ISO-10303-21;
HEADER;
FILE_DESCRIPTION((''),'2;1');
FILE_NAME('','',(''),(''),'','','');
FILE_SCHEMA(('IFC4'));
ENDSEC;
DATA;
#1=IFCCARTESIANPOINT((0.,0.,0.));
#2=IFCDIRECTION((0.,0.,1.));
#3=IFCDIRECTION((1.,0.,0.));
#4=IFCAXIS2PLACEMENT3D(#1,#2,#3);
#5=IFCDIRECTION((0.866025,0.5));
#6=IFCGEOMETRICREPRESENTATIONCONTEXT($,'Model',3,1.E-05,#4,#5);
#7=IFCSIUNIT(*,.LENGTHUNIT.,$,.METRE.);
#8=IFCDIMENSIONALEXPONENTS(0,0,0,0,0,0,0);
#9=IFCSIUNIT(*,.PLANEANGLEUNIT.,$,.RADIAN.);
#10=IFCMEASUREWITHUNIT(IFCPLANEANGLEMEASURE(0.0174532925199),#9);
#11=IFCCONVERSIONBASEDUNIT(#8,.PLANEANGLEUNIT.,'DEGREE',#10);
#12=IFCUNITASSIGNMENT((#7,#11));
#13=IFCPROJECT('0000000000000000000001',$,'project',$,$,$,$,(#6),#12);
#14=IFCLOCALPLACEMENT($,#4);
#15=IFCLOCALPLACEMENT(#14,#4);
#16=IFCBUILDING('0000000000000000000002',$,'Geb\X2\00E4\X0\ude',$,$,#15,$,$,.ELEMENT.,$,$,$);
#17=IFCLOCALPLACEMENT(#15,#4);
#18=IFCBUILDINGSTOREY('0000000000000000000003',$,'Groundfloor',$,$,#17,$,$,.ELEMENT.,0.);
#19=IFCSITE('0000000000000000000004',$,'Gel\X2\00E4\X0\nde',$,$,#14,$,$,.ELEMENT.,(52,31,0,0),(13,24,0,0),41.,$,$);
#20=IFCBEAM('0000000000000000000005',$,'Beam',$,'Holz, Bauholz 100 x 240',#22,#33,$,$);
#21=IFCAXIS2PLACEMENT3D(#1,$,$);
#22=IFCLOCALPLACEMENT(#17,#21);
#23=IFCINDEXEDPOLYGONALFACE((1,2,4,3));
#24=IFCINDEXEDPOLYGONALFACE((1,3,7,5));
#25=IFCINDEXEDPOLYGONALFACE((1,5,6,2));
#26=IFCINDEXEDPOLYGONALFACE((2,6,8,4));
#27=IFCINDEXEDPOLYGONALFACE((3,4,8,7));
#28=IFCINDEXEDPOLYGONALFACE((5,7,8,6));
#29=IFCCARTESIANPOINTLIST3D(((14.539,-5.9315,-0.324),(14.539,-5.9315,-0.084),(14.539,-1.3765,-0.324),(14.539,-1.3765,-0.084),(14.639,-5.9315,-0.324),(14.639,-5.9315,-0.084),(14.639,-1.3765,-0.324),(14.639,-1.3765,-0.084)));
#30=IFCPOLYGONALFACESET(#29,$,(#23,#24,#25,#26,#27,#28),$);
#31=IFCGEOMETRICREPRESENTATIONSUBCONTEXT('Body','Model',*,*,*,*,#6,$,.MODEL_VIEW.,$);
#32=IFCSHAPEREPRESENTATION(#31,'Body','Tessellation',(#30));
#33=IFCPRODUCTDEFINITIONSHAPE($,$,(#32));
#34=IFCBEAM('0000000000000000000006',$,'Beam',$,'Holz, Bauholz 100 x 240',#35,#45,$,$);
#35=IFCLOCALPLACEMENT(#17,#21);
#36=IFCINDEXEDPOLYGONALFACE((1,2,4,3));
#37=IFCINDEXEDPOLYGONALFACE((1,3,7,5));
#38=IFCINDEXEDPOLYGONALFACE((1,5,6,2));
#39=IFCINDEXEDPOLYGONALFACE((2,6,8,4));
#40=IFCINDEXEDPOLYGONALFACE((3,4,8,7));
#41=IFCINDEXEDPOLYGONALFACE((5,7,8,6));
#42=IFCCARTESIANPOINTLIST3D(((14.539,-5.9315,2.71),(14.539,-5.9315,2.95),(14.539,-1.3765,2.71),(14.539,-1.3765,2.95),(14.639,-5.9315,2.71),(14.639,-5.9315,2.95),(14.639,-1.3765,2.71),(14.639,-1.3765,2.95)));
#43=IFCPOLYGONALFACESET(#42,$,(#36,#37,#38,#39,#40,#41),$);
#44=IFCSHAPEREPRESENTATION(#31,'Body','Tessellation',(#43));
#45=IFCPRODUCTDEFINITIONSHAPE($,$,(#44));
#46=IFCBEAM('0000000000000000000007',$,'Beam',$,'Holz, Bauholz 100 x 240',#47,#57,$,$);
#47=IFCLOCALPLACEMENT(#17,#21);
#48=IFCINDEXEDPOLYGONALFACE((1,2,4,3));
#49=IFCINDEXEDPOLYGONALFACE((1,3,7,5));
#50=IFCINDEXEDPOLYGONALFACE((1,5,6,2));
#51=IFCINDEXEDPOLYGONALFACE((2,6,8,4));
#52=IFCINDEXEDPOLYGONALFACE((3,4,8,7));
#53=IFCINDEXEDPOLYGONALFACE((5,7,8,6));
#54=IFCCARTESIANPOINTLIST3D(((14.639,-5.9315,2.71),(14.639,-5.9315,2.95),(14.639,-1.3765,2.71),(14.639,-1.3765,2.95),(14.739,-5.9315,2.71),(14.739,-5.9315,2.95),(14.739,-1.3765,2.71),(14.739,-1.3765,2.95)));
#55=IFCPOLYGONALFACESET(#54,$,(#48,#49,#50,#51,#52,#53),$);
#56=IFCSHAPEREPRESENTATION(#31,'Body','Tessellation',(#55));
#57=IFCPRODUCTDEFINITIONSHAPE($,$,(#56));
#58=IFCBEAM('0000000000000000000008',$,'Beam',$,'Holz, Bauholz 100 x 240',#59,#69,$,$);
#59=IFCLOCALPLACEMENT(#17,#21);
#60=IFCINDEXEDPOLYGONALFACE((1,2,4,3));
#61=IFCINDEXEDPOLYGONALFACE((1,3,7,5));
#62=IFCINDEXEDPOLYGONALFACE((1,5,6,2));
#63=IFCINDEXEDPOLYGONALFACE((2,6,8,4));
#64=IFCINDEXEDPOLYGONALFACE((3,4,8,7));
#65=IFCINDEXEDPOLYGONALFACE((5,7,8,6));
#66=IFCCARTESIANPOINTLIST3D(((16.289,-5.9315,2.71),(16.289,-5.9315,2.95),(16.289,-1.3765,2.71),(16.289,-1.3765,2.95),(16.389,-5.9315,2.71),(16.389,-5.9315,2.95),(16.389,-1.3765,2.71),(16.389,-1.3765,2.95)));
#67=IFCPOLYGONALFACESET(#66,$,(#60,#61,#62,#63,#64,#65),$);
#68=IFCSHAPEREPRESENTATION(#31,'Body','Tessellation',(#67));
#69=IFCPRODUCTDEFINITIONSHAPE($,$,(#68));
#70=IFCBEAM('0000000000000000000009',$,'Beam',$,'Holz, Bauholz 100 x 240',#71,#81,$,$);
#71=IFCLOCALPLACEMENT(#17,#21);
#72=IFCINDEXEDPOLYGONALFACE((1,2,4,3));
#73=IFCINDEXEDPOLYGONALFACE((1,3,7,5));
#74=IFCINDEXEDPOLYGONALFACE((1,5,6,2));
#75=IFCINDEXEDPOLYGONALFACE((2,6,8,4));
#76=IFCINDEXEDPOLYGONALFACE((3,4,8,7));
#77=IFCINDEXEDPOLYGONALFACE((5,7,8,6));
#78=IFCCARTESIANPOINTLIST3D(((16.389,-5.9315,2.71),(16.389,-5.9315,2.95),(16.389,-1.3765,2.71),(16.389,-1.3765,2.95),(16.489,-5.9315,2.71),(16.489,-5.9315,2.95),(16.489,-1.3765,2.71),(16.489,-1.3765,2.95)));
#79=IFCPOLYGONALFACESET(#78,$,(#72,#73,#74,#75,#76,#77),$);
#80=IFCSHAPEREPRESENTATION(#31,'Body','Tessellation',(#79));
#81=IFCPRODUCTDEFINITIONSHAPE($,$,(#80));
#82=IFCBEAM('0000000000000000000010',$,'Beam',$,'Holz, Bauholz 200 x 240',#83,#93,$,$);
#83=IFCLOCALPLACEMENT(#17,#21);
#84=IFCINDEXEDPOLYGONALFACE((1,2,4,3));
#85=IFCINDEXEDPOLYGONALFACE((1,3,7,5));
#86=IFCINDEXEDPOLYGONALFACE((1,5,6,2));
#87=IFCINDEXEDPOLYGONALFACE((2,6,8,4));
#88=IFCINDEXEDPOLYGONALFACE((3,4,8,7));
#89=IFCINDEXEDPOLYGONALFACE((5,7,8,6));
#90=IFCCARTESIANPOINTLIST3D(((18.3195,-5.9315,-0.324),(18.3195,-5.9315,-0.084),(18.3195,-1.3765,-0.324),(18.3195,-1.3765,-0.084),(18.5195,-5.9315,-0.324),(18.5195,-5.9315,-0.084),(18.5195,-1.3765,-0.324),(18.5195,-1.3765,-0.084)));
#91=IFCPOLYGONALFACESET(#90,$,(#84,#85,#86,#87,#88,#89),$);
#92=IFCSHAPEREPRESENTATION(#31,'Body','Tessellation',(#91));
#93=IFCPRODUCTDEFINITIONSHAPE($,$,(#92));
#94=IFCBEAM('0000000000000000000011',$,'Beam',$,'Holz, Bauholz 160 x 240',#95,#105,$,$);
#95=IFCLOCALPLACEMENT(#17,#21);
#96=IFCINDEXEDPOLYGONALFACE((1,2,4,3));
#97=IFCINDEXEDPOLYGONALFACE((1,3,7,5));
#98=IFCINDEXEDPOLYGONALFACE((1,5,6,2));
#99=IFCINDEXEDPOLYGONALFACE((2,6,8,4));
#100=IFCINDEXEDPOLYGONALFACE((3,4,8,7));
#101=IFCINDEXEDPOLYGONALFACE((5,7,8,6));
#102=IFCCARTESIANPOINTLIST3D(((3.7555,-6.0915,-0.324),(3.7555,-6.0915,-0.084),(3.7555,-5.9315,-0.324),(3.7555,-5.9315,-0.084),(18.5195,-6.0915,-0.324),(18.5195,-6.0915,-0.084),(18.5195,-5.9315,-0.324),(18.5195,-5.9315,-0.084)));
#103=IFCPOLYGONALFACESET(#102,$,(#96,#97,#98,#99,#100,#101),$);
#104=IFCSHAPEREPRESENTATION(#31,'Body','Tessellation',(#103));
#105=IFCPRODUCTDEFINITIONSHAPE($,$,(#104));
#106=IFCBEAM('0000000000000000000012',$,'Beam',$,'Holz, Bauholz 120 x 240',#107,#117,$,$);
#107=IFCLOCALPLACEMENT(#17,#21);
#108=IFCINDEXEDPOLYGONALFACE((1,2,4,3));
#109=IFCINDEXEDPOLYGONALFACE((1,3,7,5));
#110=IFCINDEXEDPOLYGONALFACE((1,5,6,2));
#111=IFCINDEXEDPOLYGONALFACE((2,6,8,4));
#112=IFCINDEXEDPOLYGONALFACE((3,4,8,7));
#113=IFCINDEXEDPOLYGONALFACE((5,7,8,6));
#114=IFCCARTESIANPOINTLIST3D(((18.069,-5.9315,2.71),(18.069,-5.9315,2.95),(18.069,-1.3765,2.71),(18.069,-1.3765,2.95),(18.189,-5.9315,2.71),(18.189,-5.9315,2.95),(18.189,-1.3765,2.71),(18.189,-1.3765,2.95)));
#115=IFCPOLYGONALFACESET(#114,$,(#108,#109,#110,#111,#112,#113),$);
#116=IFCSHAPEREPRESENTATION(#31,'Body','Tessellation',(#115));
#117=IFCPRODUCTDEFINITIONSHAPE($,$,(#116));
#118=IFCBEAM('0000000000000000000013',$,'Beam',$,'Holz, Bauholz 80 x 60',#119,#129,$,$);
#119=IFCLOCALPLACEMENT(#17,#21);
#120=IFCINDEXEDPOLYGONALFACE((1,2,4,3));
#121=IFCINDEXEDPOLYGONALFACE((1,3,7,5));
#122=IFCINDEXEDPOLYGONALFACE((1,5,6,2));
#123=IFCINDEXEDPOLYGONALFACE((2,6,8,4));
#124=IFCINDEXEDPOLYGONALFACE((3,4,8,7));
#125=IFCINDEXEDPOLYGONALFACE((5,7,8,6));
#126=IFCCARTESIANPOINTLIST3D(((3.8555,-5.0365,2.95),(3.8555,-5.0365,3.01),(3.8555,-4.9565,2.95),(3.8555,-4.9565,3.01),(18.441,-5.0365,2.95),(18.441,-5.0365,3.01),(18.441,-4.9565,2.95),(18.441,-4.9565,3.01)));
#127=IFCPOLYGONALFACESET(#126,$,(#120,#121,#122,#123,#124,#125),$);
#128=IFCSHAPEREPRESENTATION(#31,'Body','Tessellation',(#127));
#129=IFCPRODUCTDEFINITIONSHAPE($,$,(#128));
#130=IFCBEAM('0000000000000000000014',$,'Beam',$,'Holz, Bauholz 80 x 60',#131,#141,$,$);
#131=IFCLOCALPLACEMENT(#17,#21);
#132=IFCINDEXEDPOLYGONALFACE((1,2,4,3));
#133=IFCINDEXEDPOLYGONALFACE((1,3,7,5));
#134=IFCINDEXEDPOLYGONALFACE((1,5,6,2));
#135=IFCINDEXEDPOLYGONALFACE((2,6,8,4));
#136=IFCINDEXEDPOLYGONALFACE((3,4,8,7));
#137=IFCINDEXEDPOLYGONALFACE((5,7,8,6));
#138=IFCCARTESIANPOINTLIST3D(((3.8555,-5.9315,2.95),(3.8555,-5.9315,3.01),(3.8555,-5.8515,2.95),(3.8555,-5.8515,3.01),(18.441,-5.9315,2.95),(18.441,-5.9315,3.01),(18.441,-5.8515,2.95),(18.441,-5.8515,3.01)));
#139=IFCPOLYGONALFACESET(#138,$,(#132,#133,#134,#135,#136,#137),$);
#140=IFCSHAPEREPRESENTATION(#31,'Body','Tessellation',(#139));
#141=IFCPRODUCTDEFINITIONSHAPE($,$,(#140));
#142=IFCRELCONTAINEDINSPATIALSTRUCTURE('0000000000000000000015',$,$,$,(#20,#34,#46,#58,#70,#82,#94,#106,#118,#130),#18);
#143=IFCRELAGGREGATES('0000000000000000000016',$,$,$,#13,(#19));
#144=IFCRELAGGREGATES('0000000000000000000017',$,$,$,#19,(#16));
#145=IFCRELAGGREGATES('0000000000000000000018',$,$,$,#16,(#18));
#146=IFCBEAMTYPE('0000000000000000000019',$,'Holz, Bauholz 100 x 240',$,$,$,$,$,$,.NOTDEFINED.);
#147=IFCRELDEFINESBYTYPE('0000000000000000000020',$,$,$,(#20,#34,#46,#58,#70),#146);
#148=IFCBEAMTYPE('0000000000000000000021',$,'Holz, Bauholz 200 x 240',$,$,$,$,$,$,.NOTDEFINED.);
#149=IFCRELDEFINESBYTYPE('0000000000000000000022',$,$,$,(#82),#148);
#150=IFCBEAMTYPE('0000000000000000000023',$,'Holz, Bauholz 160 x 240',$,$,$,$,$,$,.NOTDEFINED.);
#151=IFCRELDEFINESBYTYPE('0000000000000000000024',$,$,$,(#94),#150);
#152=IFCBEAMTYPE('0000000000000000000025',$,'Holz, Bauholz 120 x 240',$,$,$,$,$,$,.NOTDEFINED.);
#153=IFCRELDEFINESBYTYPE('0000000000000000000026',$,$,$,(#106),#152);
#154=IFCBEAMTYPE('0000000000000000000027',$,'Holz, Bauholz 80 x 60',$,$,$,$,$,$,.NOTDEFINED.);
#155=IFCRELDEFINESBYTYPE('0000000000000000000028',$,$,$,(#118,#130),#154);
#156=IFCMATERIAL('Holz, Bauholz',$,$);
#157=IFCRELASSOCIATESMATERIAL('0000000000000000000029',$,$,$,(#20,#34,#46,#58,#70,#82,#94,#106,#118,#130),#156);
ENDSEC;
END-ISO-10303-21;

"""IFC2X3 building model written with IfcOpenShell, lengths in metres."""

from ifc_helpers import new_model, entity, si_unit, converted_unit, direction, frame, frame_2d, origin_with_axes, place, context, subcontext, project, spatial, rectangle, extrude, material, type_object, element, save


model = new_model("IFC2X3")

# Units and contexts
model_context = context("Model", 3, precision=1e-05, world=origin_with_axes(), true_north=direction((0.866025, 0.5)))
body_context = subcontext(model_context, "Body", "Model", "MODEL_VIEW")
ifc_project = project(units=[si_unit("LENGTHUNIT", "METRE"), converted_unit("PLANEANGLEUNIT", "DEGREE", entity("IfcPlaneAngleMeasure", 0.0174532925199), si_unit("PLANEANGLEUNIT", "RADIAN"), dimensions=[0, 0, 0, 0, 0, 0, 0])], contexts=[model_context])

# Site, building, storey
site_placement = place(None, origin_with_axes())
site = spatial("IfcSite", under=ifc_project, at=site_placement, Name="Gelände", CompositionType="ELEMENT", RefLatitude=(52, 31, 0, 0), RefLongitude=(13, 24, 0, 0), RefElevation=41.0)
building_placement = place(site_placement, origin_with_axes())
building = spatial("IfcBuilding", under=site, at=building_placement, Name="Gebäude", CompositionType="ELEMENT")
storey_placement = place(building_placement, origin_with_axes())
storey = spatial("IfcBuildingStorey", under=building, at=storey_placement, Name="Groundfloor", CompositionType="ELEMENT", Elevation=0.0)

# Shared definitions
ifc_material = material(Name="Holz, Bauholz")

# Beams
beam_type_1 = type_object("IfcBeamType", Name="Holz, Bauholz 100 x 240", PredefinedType="NOTDEFINED")
for number, where, z_axis, x_axis, name in (
    (1, (14.589, -5.9315, -0.084), (0.0, 0.0, 1.0), (1.0, 0.0, 0.0), "Beam"),
):
    element("IfcBeam", number, at=place(storey_placement, frame(where, z_axis=z_axis, x_axis=x_axis)), inside=storey, type_object=beam_type_1, material=ifc_material, Name=name, ObjectType="Holz, Bauholz 100 x 240", context=body_context, shape_type="SweptSolid", body=[
        extrude(rectangle(XDim=0.24, YDim=0.1, at=frame_2d((-0.12, 0.0), x_axis=(1.0, 0.0))), frame((0.0, 0.0, 0.0), z_axis=(0.0, 1.0, 0.0), x_axis=(0.0, 0.0, 1.0)), (0.0, 0.0, 1.0), 4.555),
    ])
for number, where, z_axis, x_axis, name in (
    (2, (14.589, -5.9315, 2.95), (0.0, 0.0, 1.0), (1.0, 0.0, 0.0), "Beam"),
    (3, (14.689, -5.9315, 2.95), (0.0, 0.0, 1.0), (1.0, 0.0, 0.0), "Beam"),
    (4, (16.339, -5.9315, 2.95), (0.0, 0.0, 1.0), (1.0, 0.0, 0.0), "Beam"),
    (5, (16.439, -5.9315, 2.95), (0.0, 0.0, 1.0), (1.0, 0.0, 0.0), "Beam"),
):
    element("IfcBeam", number, at=place(storey_placement, frame(where, z_axis=z_axis, x_axis=x_axis)), inside=storey, type_object=beam_type_1, material=ifc_material, Name=name, ObjectType="Holz, Bauholz 100 x 240", context=body_context, shape_type="SweptSolid", body=[
        extrude(rectangle(XDim=0.24, YDim=0.1, at=frame_2d((-0.12, 0.0), x_axis=(1.0, 0.0))), frame((0.0, 0.0, 0.0), z_axis=(0.0, 1.0, 0.0), x_axis=(0.0, 0.0, 1.0)), (0.0, 0.0, 1.0), 4.555),
    ])
beam_type_2 = type_object("IfcBeamType", Name="Holz, Bauholz 200 x 240", PredefinedType="NOTDEFINED")
beam_1_placement = place(storey_placement, frame((18.4195, -5.9315, -0.084), z_axis=(0.0, 0.0, 1.0), x_axis=(1.0, 0.0, 0.0)))
element("IfcBeam", 6, at=beam_1_placement, inside=storey, type_object=beam_type_2, material=ifc_material, Name="Beam", ObjectType="Holz, Bauholz 200 x 240", context=body_context, shape_type="SweptSolid", body=[
    extrude(rectangle(XDim=0.24, YDim=0.2, at=frame_2d((-0.12, 0.0), x_axis=(1.0, 0.0))), frame((0.0, 0.0, 0.0), z_axis=(0.0, 1.0, 0.0), x_axis=(0.0, 0.0, 1.0)), (0.0, 0.0, 1.0), 4.555),
])
beam_type_3 = type_object("IfcBeamType", Name="Holz, Bauholz 160 x 240", PredefinedType="NOTDEFINED")
beam_2_placement = place(storey_placement, frame((18.5195, -6.0115, -0.084), z_axis=(0.0, 0.0, 1.0), x_axis=(0.0, 1.0, 0.0)))
element("IfcBeam", 7, at=beam_2_placement, inside=storey, type_object=beam_type_3, material=ifc_material, Name="Beam", ObjectType="Holz, Bauholz 160 x 240", context=body_context, shape_type="SweptSolid", body=[
    extrude(rectangle(XDim=0.24, YDim=0.16, at=frame_2d((-0.12, 0.0), x_axis=(1.0, 0.0))), frame((0.0, 0.0, 0.0), z_axis=(0.0, 1.0, 0.0), x_axis=(0.0, 0.0, 1.0)), (0.0, 0.0, 1.0), 14.764),
])
beam_type_4 = type_object("IfcBeamType", Name="Holz, Bauholz 120 x 240", PredefinedType="NOTDEFINED")
beam_3_placement = place(storey_placement, frame((18.129, -5.9315, 2.95), z_axis=(0.0, 0.0, 1.0), x_axis=(1.0, 0.0, 0.0)))
element("IfcBeam", 8, at=beam_3_placement, inside=storey, type_object=beam_type_4, material=ifc_material, Name="Beam", ObjectType="Holz, Bauholz 120 x 240", context=body_context, shape_type="SweptSolid", body=[
    extrude(rectangle(XDim=0.24, YDim=0.12, at=frame_2d((-0.12, 0.0), x_axis=(1.0, 0.0))), frame((0.0, 0.0, 0.0), z_axis=(0.0, 1.0, 0.0), x_axis=(0.0, 0.0, 1.0)), (0.0, 0.0, 1.0), 4.555),
])
beam_type_5 = type_object("IfcBeamType", Name="Holz, Bauholz 80 x 60", PredefinedType="NOTDEFINED")
for number, where, z_axis, x_axis, name in (
    (9, (18.441, -4.9965, 3.01), (0.0, 0.0, 1.0), (0.0, 1.0, 0.0), "Beam"),
    (10, (18.441, -5.8915, 3.01), (0.0, 0.0, 1.0), (0.0, 1.0, 0.0), "Beam"),
):
    element("IfcBeam", number, at=place(storey_placement, frame(where, z_axis=z_axis, x_axis=x_axis)), inside=storey, type_object=beam_type_5, material=ifc_material, Name=name, ObjectType="Holz, Bauholz 80 x 60", context=body_context, shape_type="SweptSolid", body=[
        extrude(rectangle(XDim=0.06, YDim=0.08, at=frame_2d((-0.03, 0.0), x_axis=(1.0, 0.0))), frame((0.0, 0.0, 0.0), z_axis=(0.0, 1.0, 0.0), x_axis=(0.0, 0.0, 1.0)), (0.0, 0.0, 1.0), 14.5855),
    ])

save(model, "model.ifc")
